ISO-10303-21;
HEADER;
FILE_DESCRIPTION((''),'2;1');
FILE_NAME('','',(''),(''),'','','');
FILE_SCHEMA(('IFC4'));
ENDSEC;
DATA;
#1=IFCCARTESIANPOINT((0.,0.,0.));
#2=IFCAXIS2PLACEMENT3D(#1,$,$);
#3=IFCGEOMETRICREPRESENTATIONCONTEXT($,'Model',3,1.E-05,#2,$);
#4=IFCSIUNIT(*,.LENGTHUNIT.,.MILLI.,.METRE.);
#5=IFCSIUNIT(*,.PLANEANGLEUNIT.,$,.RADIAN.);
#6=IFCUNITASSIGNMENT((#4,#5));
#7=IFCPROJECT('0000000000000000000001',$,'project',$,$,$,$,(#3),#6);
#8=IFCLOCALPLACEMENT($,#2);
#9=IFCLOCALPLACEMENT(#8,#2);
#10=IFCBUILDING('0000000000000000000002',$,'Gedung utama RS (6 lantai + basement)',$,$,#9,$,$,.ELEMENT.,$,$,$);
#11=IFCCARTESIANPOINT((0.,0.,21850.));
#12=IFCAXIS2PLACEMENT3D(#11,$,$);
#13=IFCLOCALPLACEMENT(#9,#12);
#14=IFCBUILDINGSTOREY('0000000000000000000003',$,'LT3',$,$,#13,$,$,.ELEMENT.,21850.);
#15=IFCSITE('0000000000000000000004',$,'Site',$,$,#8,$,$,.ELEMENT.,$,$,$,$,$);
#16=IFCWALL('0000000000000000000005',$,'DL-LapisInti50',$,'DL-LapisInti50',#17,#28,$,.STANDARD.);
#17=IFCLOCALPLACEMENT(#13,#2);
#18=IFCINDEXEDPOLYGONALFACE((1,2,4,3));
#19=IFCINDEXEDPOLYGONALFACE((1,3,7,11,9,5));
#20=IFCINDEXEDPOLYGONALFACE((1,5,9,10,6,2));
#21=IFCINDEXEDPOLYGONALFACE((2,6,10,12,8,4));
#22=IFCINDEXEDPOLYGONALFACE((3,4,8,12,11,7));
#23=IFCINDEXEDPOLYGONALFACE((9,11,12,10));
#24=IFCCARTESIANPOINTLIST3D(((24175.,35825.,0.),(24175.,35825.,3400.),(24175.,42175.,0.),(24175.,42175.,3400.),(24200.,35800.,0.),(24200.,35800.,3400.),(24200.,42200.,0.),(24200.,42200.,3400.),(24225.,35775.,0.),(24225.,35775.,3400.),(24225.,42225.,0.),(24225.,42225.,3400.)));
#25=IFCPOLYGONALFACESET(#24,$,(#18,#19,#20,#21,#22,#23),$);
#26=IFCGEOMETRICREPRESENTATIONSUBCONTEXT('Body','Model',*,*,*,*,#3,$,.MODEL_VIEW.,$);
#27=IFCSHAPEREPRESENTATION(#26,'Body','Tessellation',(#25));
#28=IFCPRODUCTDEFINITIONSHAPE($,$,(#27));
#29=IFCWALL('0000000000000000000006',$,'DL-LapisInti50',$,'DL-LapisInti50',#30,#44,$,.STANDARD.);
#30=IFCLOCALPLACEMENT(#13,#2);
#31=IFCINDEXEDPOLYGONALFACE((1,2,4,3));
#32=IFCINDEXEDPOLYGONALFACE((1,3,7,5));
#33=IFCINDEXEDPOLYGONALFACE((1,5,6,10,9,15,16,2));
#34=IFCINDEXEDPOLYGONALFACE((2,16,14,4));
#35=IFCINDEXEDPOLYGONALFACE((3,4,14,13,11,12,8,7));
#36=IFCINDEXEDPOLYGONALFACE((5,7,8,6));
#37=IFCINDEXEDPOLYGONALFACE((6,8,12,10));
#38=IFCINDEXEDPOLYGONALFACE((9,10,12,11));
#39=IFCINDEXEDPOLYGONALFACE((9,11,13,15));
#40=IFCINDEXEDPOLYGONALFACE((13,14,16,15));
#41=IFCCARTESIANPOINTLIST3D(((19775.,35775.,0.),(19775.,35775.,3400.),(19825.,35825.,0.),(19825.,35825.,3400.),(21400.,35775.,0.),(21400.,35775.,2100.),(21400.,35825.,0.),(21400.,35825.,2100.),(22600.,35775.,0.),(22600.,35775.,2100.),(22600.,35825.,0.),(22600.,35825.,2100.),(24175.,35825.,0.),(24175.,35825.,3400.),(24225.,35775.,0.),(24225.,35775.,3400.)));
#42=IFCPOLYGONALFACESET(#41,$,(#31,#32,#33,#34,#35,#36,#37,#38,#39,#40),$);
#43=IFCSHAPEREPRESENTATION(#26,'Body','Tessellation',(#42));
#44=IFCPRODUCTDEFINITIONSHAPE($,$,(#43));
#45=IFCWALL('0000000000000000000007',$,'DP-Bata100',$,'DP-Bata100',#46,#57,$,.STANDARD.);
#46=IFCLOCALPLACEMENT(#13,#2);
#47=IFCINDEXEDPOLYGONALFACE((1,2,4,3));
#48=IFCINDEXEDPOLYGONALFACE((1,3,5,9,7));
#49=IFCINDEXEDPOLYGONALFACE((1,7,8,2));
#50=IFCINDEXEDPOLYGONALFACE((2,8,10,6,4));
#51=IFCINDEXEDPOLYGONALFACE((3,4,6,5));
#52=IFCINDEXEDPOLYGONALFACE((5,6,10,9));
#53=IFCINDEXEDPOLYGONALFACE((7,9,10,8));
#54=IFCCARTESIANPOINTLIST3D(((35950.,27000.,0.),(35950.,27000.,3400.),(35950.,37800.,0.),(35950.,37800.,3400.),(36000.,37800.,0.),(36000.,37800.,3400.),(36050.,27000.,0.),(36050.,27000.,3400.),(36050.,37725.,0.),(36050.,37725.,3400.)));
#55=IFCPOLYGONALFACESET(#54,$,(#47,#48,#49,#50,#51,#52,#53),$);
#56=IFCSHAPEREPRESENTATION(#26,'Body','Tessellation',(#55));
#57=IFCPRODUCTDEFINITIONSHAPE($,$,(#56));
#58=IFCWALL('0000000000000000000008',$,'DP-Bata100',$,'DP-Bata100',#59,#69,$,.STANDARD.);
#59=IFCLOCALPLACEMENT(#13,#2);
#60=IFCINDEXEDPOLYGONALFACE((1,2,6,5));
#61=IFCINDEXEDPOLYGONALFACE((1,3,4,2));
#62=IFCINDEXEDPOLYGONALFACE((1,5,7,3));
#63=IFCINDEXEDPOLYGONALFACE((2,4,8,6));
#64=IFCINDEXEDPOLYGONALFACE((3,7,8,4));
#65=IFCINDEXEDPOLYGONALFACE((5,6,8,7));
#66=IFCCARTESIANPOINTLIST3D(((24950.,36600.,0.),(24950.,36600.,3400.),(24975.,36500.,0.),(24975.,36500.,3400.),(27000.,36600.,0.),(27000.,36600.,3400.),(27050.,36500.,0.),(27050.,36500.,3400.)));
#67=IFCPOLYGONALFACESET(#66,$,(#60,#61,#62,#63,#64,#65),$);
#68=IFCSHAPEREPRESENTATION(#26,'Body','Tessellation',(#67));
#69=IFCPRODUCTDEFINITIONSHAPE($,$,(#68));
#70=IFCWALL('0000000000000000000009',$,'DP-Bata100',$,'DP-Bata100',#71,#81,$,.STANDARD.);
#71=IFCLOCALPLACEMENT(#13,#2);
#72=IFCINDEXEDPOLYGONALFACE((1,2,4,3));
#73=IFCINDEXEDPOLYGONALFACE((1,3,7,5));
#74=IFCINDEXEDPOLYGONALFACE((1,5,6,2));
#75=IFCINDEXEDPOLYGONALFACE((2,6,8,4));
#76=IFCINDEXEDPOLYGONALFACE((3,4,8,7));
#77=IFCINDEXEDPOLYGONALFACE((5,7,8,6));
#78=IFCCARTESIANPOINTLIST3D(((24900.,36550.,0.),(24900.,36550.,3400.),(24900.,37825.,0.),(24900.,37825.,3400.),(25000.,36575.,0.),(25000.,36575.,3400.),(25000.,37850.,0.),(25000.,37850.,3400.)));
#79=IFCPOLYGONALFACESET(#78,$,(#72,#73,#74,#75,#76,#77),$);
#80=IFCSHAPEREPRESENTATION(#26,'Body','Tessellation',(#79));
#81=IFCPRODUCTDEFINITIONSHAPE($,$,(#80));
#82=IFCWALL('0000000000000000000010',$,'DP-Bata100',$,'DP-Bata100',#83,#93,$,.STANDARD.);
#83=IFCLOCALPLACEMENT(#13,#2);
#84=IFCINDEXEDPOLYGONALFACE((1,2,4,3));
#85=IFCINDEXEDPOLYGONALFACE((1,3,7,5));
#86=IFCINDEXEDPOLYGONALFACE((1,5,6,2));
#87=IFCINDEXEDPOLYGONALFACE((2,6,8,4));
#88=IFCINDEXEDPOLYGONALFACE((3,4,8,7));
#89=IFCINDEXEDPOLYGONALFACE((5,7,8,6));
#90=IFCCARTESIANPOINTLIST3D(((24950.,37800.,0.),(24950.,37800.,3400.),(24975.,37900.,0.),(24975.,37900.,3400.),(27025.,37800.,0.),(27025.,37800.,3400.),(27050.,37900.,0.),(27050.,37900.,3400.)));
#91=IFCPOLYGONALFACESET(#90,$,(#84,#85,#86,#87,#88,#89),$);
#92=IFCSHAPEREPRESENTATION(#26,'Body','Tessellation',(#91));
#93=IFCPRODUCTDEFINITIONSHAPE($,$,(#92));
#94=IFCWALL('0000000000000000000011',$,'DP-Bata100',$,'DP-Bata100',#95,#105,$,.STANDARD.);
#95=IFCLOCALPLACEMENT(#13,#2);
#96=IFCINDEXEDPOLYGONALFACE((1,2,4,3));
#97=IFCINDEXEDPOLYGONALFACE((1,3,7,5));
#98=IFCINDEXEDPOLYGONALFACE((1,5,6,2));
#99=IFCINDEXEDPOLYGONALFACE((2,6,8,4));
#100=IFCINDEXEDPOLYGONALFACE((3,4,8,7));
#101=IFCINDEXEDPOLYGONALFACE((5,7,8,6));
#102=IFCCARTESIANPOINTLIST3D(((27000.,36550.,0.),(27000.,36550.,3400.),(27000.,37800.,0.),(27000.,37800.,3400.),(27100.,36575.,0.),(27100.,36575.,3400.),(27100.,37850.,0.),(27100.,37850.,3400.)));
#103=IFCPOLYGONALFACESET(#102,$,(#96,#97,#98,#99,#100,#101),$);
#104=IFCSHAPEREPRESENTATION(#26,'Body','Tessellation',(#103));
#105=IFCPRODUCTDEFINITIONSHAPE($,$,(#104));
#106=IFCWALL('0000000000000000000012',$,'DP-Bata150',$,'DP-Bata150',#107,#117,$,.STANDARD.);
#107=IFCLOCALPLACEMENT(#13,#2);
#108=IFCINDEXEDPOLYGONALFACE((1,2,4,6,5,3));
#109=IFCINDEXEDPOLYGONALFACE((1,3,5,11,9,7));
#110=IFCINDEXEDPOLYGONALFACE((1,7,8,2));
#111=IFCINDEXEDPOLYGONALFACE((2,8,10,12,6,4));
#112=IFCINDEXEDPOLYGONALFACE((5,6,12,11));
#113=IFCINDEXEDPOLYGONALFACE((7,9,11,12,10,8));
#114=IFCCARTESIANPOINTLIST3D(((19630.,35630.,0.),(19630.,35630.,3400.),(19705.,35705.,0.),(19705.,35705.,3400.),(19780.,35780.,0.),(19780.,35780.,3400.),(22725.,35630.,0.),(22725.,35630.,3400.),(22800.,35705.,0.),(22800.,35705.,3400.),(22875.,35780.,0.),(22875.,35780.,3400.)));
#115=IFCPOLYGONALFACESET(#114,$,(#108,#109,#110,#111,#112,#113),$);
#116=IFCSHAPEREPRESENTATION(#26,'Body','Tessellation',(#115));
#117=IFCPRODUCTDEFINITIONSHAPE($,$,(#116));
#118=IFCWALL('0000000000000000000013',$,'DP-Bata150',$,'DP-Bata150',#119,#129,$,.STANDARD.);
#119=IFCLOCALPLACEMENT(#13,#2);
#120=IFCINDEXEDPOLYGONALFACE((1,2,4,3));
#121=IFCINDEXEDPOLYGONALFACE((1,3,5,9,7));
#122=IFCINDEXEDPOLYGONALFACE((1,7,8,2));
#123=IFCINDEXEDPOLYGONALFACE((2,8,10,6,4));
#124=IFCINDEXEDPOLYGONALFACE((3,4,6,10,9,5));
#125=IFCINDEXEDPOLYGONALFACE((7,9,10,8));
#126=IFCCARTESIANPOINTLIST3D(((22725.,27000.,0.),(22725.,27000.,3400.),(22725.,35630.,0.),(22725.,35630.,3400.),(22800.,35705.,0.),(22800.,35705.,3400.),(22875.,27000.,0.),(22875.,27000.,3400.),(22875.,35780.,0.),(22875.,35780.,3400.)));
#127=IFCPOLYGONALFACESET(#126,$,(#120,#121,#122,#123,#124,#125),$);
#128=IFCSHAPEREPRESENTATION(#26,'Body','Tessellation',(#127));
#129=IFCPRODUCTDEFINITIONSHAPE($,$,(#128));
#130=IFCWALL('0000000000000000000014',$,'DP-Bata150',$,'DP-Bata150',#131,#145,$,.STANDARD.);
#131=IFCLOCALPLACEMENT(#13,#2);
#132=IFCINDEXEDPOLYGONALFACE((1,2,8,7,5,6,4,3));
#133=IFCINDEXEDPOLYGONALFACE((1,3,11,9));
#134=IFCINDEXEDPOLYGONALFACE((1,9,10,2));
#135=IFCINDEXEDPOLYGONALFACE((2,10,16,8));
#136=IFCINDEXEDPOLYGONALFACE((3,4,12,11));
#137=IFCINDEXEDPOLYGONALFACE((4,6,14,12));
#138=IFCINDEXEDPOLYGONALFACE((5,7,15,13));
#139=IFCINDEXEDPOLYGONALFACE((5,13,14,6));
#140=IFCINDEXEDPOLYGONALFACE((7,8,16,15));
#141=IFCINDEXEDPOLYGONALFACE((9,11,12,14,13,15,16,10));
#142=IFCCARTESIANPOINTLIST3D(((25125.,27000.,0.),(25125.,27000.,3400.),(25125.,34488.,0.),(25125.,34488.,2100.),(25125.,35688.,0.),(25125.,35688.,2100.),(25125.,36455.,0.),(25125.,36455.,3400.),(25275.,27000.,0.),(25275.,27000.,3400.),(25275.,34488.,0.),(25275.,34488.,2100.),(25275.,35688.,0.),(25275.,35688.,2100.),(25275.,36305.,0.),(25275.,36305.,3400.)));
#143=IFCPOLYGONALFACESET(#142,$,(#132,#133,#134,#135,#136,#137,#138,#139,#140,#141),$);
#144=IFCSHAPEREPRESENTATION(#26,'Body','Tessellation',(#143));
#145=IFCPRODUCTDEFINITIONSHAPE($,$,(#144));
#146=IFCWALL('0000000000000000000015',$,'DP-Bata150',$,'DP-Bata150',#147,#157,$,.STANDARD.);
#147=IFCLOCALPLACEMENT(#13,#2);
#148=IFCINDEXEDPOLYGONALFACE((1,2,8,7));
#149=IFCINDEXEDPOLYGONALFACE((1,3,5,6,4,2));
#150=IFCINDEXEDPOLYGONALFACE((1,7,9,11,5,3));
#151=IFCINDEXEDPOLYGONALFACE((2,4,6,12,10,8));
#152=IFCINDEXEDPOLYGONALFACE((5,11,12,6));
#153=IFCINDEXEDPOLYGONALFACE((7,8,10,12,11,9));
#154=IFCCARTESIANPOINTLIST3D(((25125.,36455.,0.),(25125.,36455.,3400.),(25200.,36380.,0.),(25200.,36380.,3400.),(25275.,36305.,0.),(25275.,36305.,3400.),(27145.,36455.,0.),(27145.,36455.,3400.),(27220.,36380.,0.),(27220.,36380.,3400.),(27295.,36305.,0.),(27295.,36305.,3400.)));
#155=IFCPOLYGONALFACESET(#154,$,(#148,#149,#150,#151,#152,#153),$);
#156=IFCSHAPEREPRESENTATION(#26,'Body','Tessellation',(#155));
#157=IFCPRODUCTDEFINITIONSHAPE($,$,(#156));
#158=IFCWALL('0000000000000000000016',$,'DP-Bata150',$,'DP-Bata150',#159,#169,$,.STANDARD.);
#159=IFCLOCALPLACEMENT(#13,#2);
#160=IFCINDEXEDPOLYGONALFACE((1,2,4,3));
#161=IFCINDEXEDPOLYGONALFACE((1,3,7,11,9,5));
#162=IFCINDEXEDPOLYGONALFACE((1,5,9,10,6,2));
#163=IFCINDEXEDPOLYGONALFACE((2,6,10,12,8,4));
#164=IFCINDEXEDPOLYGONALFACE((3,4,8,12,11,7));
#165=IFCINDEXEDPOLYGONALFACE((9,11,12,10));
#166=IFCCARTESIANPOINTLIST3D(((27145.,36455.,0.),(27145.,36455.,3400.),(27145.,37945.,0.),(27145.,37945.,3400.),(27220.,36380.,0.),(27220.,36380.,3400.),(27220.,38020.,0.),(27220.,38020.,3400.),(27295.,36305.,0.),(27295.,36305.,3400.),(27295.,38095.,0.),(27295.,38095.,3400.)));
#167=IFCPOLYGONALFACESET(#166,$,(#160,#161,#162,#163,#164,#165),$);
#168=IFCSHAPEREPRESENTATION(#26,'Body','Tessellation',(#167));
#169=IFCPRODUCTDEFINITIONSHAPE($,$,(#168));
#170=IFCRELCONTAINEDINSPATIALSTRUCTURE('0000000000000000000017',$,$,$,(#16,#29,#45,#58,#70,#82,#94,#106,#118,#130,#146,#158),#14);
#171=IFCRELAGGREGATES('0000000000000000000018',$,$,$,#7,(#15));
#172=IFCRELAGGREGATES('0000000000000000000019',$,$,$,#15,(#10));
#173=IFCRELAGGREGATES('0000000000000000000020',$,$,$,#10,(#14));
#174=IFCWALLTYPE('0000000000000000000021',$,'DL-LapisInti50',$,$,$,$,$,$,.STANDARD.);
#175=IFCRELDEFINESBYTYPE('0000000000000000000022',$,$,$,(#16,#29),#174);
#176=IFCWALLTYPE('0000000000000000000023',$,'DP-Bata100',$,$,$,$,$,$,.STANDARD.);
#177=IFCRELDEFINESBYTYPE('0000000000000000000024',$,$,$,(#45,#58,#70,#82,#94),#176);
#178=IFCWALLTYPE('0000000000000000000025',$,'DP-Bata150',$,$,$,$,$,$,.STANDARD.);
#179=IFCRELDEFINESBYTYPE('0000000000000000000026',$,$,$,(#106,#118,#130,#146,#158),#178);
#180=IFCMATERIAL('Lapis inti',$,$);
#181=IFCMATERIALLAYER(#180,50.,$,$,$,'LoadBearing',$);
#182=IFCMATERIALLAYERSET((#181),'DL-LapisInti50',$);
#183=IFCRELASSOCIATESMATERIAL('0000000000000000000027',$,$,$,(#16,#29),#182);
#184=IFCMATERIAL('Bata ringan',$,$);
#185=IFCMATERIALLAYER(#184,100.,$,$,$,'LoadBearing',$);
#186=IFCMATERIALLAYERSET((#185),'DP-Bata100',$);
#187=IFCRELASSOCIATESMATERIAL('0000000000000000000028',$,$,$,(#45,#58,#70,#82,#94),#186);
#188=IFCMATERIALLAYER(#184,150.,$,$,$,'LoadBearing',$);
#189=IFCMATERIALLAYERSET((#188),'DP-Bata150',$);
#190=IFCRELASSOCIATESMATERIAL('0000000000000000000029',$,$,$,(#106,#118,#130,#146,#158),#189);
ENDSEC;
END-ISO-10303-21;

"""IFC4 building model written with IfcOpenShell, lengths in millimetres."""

from ifc_helpers import new_model, si_unit, frame, frame_2d, origin, place, context, subcontext, project, spatial, polyline, rectangle, outline, extrude, material, layer, layer_set, layer_usage, type_object, element, save


model = new_model("IFC4")

# Units and contexts
model_context = context("Model", 3, precision=1e-05, world=origin())
body_context = subcontext(model_context, "Body", "Model", "MODEL_VIEW")
ifc_project = project(units=[si_unit("LENGTHUNIT", "METRE", prefix="MILLI"), si_unit("PLANEANGLEUNIT", "RADIAN")], contexts=[model_context])

# Site, building, storey
site_placement = place(None, origin())
site = spatial("IfcSite", under=ifc_project, at=site_placement, Name="Site", CompositionType="ELEMENT")
building_placement = place(site_placement, origin())
building = spatial("IfcBuilding", under=site, at=building_placement, Name="Gedung utama RS (6 lantai + basement)", CompositionType="ELEMENT")
storey_placement = place(building_placement, frame((0.0, 0.0, 21850.0)))
storey = spatial("IfcBuildingStorey", under=building, at=storey_placement, Name="LT3", CompositionType="ELEMENT", Elevation=21850.0)

# Wall
ifc_material_1 = material(Name="Lapis inti")
ifc_layer_1 = layer(ifc_material_1, 50.0, Category="LoadBearing")
ifc_layer_set_1 = layer_set([ifc_layer_1], Name="DL-LapisInti50")
ifc_layer_usage_1 = layer_usage(ifc_layer_set_1, "AXIS2", "NEGATIVE", 25.0)
wall_type_1 = type_object("IfcWallType", Name="DL-LapisInti50", PredefinedType="STANDARD")
wall_1_placement = place(storey_placement, frame((24200.0, 35800.0, 0.0), z_axis=(0.0, 0.0, 1.0), x_axis=(0.0, 1.0, 0.0)))
element("IfcWall", 1, at=wall_1_placement, inside=storey, type_object=wall_type_1, material=ifc_layer_usage_1, Name="DL-LapisInti50", ObjectType="DL-LapisInti50", PredefinedType="STANDARD", context=body_context, shape_type="SweptSolid", body=[
    extrude(outline(polyline([(-25.0, -25.0), (0.0, 0.0), (25.0, 25.0), (6375.0, 25.0), (6400.0, 0.0), (6425.0, -25.0), (-25.0, -25.0)])), origin(), (0.0, 0.0, 1.0), 3400.0),
])

# Wall, opening
wall_2_placement = place(storey_placement, frame((19800.0, 35800.0, 0.0), z_axis=(0.0, 0.0, 1.0), x_axis=(1.0, 0.0, 0.0)))
wall_2 = element("IfcWall", 2, at=wall_2_placement, inside=storey, type_object=wall_type_1, material=ifc_layer_usage_1, Name="DL-LapisInti50", ObjectType="DL-LapisInti50", PredefinedType="STANDARD", context=body_context, shape_type="SweptSolid", body=[
    extrude(outline(polyline([(-25.0, -25.0), (0.0, 0.0), (25.0, 25.0), (4375.0, 25.0), (4400.0, 0.0), (4425.0, -25.0), (-25.0, -25.0)])), origin(), (0.0, 0.0, 1.0), 3400.0),
])
opening_1_placement = place(wall_2_placement, frame((1600.0, 0.0, 0.0), z_axis=(0.0, 0.0, 1.0), x_axis=(1.0, 0.0, 0.0)))
element("IfcOpeningElement", 3, at=opening_1_placement, cuts=wall_2, PredefinedType="OPENING", context=body_context, shape_type="SweptSolid", body=[
    extrude(rectangle(XDim=1200.0, YDim=70.0, at=frame_2d((600.0, 0.0))), origin(), (0.0, 0.0, 1.0), 2100.0),
])

# Walls
ifc_material_2 = material(Name="Bata ringan")
ifc_layer_2 = layer(ifc_material_2, 100.0, Category="LoadBearing")
ifc_layer_set_2 = layer_set([ifc_layer_2], Name="DP-Bata100")
ifc_layer_usage_2 = layer_usage(ifc_layer_set_2, "AXIS2", "NEGATIVE", 50.0)
wall_type_2 = type_object("IfcWallType", Name="DP-Bata100", PredefinedType="STANDARD")
wall_3_placement = place(storey_placement, frame((36000.0, 37800.0, 0.0), z_axis=(0.0, 0.0, 1.0), x_axis=(0.0, -1.0, 0.0)))
element("IfcWall", 4, at=wall_3_placement, inside=storey, type_object=wall_type_2, material=ifc_layer_usage_2, Name="DP-Bata100", ObjectType="DP-Bata100", PredefinedType="STANDARD", context=body_context, shape_type="SweptSolid", body=[
    extrude(outline(polyline([(0.0, -50.0), (0.0, 0.0), (75.0, 50.0), (10800.0, 50.0), (10800.0, -50.0), (0.0, -50.0)])), origin(), (0.0, 0.0, 1.0), 3400.0),
])
wall_4_placement = place(storey_placement, frame((27050.0, 36550.0, 0.0), z_axis=(0.0, 0.0, 1.0), x_axis=(-1.0, 0.0, 0.0)))
element("IfcWall", 5, at=wall_4_placement, inside=storey, type_object=wall_type_2, material=ifc_layer_usage_2, Name="DP-Bata100", ObjectType="DP-Bata100", PredefinedType="STANDARD", context=body_context, shape_type="SweptSolid", body=[
    extrude(outline(polyline([(50.0, -50.0), (0.0, 50.0), (2075.0, 50.0), (2100.0, -50.0), (50.0, -50.0)])), origin(), (0.0, 0.0, 1.0), 3400.0),
])
wall_5_placement = place(storey_placement, frame((24950.0, 36550.0, 0.0), z_axis=(0.0, 0.0, 1.0), x_axis=(0.0, 1.0, 0.0)))
element("IfcWall", 6, at=wall_5_placement, inside=storey, type_object=wall_type_2, material=ifc_layer_usage_2, Name="DP-Bata100", ObjectType="DP-Bata100", PredefinedType="STANDARD", context=body_context, shape_type="SweptSolid", body=[
    extrude(outline(polyline([(25.0, -50.0), (0.0, 50.0), (1275.0, 50.0), (1300.0, -50.0), (25.0, -50.0)])), origin(), (0.0, 0.0, 1.0), 3400.0),
])
wall_6_placement = place(storey_placement, frame((24950.0, 37850.0, 0.0), z_axis=(0.0, 0.0, 1.0), x_axis=(1.0, 0.0, 0.0)))
element("IfcWall", 7, at=wall_6_placement, inside=storey, type_object=wall_type_2, material=ifc_layer_usage_2, Name="DP-Bata100", ObjectType="DP-Bata100", PredefinedType="STANDARD", context=body_context, shape_type="SweptSolid", body=[
    extrude(outline(polyline([(0.0, -50.0), (25.0, 50.0), (2100.0, 50.0), (2075.0, -50.0), (0.0, -50.0)])), origin(), (0.0, 0.0, 1.0), 3400.0),
])
wall_7_placement = place(storey_placement, frame((27050.0, 37850.0, 0.0), z_axis=(0.0, 0.0, 1.0), x_axis=(0.0, -1.0, 0.0)))
element("IfcWall", 8, at=wall_7_placement, inside=storey, type_object=wall_type_2, material=ifc_layer_usage_2, Name="DP-Bata100", ObjectType="DP-Bata100", PredefinedType="STANDARD", context=body_context, shape_type="SweptSolid", body=[
    extrude(outline(polyline([(50.0, -50.0), (0.0, 50.0), (1275.0, 50.0), (1300.0, -50.0), (50.0, -50.0)])), origin(), (0.0, 0.0, 1.0), 3400.0),
])
ifc_layer_3 = layer(ifc_material_2, 150.0, Category="LoadBearing")
ifc_layer_set_3 = layer_set([ifc_layer_3], Name="DP-Bata150")
ifc_layer_usage_3 = layer_usage(ifc_layer_set_3, "AXIS2", "NEGATIVE", 75.0)
wall_type_3 = type_object("IfcWallType", Name="DP-Bata150", PredefinedType="STANDARD")
wall_8_placement = place(storey_placement, frame((19705.0, 35705.0, 0.0), z_axis=(0.0, 0.0, 1.0), x_axis=(1.0, 0.0, 0.0)))
element("IfcWall", 9, at=wall_8_placement, inside=storey, type_object=wall_type_3, material=ifc_layer_usage_3, Name="DP-Bata150", ObjectType="DP-Bata150", PredefinedType="STANDARD", context=body_context, shape_type="SweptSolid", body=[
    extrude(outline(polyline([(-75.0, -75.0), (0.0, 0.0), (75.0, 75.0), (3170.0, 75.0), (3095.0, 0.0), (3020.0, -75.0), (-75.0, -75.0)])), origin(), (0.0, 0.0, 1.0), 3400.0),
])
wall_9_placement = place(storey_placement, frame((22800.0, 35705.0, 0.0), z_axis=(0.0, 0.0, 1.0), x_axis=(0.0, -1.0, 0.0)))
element("IfcWall", 10, at=wall_9_placement, inside=storey, type_object=wall_type_3, material=ifc_layer_usage_3, Name="DP-Bata150", ObjectType="DP-Bata150", PredefinedType="STANDARD", context=body_context, shape_type="SweptSolid", body=[
    extrude(outline(polyline([(75.0, -75.0), (0.0, 0.0), (-75.0, 75.0), (8705.0, 75.0), (8705.0, -75.0), (75.0, -75.0)])), origin(), (0.0, 0.0, 1.0), 3400.0),
])

# Wall, opening
wall_10_placement = place(storey_placement, frame((25200.0, 27000.0, 0.0), z_axis=(0.0, 0.0, 1.0), x_axis=(0.0, 1.0, 0.0)))
wall_10 = element("IfcWall", 11, at=wall_10_placement, inside=storey, type_object=wall_type_3, material=ifc_layer_usage_3, Name="DP-Bata150", ObjectType="DP-Bata150", PredefinedType="STANDARD", context=body_context, shape_type="SweptSolid", body=[
    extrude(outline(polyline([(0.0, -75.0), (0.0, 75.0), (9455.0, 75.0), (9380.0, 0.0), (9305.0, -75.0), (0.0, -75.0)])), origin(), (0.0, 0.0, 1.0), 3400.0),
])
opening_2_placement = place(wall_10_placement, frame((7488.0, 0.0, 0.0), z_axis=(0.0, 0.0, 1.0), x_axis=(1.0, 0.0, 0.0)))
element("IfcOpeningElement", 12, at=opening_2_placement, cuts=wall_10, PredefinedType="OPENING", context=body_context, shape_type="SweptSolid", body=[
    extrude(rectangle(XDim=1200.0, YDim=170.0, at=frame_2d((600.0, 0.0))), origin(), (0.0, 0.0, 1.0), 2100.0),
])

# Walls
wall_11_placement = place(storey_placement, frame((25200.0, 36380.0, 0.0), z_axis=(0.0, 0.0, 1.0), x_axis=(1.0, 0.0, 0.0)))
element("IfcWall", 13, at=wall_11_placement, inside=storey, type_object=wall_type_3, material=ifc_layer_usage_3, Name="DP-Bata150", ObjectType="DP-Bata150", PredefinedType="STANDARD", context=body_context, shape_type="SweptSolid", body=[
    extrude(outline(polyline([(75.0, -75.0), (0.0, 0.0), (-75.0, 75.0), (1945.0, 75.0), (2020.0, 0.0), (2095.0, -75.0), (75.0, -75.0)])), origin(), (0.0, 0.0, 1.0), 3400.0),
])
wall_12_placement = place(storey_placement, frame((27220.0, 36380.0, 0.0), z_axis=(0.0, 0.0, 1.0), x_axis=(0.0, 1.0, 0.0)))
element("IfcWall", 14, at=wall_12_placement, inside=storey, type_object=wall_type_3, material=ifc_layer_usage_3, Name="DP-Bata150", ObjectType="DP-Bata150", PredefinedType="STANDARD", context=body_context, shape_type="SweptSolid", body=[
    extrude(outline(polyline([(-75.0, -75.0), (0.0, 0.0), (75.0, 75.0), (1565.0, 75.0), (1640.0, 0.0), (1715.0, -75.0), (-75.0, -75.0)])), origin(), (0.0, 0.0, 1.0), 3400.0),
])

save(model, "model.ifc")
